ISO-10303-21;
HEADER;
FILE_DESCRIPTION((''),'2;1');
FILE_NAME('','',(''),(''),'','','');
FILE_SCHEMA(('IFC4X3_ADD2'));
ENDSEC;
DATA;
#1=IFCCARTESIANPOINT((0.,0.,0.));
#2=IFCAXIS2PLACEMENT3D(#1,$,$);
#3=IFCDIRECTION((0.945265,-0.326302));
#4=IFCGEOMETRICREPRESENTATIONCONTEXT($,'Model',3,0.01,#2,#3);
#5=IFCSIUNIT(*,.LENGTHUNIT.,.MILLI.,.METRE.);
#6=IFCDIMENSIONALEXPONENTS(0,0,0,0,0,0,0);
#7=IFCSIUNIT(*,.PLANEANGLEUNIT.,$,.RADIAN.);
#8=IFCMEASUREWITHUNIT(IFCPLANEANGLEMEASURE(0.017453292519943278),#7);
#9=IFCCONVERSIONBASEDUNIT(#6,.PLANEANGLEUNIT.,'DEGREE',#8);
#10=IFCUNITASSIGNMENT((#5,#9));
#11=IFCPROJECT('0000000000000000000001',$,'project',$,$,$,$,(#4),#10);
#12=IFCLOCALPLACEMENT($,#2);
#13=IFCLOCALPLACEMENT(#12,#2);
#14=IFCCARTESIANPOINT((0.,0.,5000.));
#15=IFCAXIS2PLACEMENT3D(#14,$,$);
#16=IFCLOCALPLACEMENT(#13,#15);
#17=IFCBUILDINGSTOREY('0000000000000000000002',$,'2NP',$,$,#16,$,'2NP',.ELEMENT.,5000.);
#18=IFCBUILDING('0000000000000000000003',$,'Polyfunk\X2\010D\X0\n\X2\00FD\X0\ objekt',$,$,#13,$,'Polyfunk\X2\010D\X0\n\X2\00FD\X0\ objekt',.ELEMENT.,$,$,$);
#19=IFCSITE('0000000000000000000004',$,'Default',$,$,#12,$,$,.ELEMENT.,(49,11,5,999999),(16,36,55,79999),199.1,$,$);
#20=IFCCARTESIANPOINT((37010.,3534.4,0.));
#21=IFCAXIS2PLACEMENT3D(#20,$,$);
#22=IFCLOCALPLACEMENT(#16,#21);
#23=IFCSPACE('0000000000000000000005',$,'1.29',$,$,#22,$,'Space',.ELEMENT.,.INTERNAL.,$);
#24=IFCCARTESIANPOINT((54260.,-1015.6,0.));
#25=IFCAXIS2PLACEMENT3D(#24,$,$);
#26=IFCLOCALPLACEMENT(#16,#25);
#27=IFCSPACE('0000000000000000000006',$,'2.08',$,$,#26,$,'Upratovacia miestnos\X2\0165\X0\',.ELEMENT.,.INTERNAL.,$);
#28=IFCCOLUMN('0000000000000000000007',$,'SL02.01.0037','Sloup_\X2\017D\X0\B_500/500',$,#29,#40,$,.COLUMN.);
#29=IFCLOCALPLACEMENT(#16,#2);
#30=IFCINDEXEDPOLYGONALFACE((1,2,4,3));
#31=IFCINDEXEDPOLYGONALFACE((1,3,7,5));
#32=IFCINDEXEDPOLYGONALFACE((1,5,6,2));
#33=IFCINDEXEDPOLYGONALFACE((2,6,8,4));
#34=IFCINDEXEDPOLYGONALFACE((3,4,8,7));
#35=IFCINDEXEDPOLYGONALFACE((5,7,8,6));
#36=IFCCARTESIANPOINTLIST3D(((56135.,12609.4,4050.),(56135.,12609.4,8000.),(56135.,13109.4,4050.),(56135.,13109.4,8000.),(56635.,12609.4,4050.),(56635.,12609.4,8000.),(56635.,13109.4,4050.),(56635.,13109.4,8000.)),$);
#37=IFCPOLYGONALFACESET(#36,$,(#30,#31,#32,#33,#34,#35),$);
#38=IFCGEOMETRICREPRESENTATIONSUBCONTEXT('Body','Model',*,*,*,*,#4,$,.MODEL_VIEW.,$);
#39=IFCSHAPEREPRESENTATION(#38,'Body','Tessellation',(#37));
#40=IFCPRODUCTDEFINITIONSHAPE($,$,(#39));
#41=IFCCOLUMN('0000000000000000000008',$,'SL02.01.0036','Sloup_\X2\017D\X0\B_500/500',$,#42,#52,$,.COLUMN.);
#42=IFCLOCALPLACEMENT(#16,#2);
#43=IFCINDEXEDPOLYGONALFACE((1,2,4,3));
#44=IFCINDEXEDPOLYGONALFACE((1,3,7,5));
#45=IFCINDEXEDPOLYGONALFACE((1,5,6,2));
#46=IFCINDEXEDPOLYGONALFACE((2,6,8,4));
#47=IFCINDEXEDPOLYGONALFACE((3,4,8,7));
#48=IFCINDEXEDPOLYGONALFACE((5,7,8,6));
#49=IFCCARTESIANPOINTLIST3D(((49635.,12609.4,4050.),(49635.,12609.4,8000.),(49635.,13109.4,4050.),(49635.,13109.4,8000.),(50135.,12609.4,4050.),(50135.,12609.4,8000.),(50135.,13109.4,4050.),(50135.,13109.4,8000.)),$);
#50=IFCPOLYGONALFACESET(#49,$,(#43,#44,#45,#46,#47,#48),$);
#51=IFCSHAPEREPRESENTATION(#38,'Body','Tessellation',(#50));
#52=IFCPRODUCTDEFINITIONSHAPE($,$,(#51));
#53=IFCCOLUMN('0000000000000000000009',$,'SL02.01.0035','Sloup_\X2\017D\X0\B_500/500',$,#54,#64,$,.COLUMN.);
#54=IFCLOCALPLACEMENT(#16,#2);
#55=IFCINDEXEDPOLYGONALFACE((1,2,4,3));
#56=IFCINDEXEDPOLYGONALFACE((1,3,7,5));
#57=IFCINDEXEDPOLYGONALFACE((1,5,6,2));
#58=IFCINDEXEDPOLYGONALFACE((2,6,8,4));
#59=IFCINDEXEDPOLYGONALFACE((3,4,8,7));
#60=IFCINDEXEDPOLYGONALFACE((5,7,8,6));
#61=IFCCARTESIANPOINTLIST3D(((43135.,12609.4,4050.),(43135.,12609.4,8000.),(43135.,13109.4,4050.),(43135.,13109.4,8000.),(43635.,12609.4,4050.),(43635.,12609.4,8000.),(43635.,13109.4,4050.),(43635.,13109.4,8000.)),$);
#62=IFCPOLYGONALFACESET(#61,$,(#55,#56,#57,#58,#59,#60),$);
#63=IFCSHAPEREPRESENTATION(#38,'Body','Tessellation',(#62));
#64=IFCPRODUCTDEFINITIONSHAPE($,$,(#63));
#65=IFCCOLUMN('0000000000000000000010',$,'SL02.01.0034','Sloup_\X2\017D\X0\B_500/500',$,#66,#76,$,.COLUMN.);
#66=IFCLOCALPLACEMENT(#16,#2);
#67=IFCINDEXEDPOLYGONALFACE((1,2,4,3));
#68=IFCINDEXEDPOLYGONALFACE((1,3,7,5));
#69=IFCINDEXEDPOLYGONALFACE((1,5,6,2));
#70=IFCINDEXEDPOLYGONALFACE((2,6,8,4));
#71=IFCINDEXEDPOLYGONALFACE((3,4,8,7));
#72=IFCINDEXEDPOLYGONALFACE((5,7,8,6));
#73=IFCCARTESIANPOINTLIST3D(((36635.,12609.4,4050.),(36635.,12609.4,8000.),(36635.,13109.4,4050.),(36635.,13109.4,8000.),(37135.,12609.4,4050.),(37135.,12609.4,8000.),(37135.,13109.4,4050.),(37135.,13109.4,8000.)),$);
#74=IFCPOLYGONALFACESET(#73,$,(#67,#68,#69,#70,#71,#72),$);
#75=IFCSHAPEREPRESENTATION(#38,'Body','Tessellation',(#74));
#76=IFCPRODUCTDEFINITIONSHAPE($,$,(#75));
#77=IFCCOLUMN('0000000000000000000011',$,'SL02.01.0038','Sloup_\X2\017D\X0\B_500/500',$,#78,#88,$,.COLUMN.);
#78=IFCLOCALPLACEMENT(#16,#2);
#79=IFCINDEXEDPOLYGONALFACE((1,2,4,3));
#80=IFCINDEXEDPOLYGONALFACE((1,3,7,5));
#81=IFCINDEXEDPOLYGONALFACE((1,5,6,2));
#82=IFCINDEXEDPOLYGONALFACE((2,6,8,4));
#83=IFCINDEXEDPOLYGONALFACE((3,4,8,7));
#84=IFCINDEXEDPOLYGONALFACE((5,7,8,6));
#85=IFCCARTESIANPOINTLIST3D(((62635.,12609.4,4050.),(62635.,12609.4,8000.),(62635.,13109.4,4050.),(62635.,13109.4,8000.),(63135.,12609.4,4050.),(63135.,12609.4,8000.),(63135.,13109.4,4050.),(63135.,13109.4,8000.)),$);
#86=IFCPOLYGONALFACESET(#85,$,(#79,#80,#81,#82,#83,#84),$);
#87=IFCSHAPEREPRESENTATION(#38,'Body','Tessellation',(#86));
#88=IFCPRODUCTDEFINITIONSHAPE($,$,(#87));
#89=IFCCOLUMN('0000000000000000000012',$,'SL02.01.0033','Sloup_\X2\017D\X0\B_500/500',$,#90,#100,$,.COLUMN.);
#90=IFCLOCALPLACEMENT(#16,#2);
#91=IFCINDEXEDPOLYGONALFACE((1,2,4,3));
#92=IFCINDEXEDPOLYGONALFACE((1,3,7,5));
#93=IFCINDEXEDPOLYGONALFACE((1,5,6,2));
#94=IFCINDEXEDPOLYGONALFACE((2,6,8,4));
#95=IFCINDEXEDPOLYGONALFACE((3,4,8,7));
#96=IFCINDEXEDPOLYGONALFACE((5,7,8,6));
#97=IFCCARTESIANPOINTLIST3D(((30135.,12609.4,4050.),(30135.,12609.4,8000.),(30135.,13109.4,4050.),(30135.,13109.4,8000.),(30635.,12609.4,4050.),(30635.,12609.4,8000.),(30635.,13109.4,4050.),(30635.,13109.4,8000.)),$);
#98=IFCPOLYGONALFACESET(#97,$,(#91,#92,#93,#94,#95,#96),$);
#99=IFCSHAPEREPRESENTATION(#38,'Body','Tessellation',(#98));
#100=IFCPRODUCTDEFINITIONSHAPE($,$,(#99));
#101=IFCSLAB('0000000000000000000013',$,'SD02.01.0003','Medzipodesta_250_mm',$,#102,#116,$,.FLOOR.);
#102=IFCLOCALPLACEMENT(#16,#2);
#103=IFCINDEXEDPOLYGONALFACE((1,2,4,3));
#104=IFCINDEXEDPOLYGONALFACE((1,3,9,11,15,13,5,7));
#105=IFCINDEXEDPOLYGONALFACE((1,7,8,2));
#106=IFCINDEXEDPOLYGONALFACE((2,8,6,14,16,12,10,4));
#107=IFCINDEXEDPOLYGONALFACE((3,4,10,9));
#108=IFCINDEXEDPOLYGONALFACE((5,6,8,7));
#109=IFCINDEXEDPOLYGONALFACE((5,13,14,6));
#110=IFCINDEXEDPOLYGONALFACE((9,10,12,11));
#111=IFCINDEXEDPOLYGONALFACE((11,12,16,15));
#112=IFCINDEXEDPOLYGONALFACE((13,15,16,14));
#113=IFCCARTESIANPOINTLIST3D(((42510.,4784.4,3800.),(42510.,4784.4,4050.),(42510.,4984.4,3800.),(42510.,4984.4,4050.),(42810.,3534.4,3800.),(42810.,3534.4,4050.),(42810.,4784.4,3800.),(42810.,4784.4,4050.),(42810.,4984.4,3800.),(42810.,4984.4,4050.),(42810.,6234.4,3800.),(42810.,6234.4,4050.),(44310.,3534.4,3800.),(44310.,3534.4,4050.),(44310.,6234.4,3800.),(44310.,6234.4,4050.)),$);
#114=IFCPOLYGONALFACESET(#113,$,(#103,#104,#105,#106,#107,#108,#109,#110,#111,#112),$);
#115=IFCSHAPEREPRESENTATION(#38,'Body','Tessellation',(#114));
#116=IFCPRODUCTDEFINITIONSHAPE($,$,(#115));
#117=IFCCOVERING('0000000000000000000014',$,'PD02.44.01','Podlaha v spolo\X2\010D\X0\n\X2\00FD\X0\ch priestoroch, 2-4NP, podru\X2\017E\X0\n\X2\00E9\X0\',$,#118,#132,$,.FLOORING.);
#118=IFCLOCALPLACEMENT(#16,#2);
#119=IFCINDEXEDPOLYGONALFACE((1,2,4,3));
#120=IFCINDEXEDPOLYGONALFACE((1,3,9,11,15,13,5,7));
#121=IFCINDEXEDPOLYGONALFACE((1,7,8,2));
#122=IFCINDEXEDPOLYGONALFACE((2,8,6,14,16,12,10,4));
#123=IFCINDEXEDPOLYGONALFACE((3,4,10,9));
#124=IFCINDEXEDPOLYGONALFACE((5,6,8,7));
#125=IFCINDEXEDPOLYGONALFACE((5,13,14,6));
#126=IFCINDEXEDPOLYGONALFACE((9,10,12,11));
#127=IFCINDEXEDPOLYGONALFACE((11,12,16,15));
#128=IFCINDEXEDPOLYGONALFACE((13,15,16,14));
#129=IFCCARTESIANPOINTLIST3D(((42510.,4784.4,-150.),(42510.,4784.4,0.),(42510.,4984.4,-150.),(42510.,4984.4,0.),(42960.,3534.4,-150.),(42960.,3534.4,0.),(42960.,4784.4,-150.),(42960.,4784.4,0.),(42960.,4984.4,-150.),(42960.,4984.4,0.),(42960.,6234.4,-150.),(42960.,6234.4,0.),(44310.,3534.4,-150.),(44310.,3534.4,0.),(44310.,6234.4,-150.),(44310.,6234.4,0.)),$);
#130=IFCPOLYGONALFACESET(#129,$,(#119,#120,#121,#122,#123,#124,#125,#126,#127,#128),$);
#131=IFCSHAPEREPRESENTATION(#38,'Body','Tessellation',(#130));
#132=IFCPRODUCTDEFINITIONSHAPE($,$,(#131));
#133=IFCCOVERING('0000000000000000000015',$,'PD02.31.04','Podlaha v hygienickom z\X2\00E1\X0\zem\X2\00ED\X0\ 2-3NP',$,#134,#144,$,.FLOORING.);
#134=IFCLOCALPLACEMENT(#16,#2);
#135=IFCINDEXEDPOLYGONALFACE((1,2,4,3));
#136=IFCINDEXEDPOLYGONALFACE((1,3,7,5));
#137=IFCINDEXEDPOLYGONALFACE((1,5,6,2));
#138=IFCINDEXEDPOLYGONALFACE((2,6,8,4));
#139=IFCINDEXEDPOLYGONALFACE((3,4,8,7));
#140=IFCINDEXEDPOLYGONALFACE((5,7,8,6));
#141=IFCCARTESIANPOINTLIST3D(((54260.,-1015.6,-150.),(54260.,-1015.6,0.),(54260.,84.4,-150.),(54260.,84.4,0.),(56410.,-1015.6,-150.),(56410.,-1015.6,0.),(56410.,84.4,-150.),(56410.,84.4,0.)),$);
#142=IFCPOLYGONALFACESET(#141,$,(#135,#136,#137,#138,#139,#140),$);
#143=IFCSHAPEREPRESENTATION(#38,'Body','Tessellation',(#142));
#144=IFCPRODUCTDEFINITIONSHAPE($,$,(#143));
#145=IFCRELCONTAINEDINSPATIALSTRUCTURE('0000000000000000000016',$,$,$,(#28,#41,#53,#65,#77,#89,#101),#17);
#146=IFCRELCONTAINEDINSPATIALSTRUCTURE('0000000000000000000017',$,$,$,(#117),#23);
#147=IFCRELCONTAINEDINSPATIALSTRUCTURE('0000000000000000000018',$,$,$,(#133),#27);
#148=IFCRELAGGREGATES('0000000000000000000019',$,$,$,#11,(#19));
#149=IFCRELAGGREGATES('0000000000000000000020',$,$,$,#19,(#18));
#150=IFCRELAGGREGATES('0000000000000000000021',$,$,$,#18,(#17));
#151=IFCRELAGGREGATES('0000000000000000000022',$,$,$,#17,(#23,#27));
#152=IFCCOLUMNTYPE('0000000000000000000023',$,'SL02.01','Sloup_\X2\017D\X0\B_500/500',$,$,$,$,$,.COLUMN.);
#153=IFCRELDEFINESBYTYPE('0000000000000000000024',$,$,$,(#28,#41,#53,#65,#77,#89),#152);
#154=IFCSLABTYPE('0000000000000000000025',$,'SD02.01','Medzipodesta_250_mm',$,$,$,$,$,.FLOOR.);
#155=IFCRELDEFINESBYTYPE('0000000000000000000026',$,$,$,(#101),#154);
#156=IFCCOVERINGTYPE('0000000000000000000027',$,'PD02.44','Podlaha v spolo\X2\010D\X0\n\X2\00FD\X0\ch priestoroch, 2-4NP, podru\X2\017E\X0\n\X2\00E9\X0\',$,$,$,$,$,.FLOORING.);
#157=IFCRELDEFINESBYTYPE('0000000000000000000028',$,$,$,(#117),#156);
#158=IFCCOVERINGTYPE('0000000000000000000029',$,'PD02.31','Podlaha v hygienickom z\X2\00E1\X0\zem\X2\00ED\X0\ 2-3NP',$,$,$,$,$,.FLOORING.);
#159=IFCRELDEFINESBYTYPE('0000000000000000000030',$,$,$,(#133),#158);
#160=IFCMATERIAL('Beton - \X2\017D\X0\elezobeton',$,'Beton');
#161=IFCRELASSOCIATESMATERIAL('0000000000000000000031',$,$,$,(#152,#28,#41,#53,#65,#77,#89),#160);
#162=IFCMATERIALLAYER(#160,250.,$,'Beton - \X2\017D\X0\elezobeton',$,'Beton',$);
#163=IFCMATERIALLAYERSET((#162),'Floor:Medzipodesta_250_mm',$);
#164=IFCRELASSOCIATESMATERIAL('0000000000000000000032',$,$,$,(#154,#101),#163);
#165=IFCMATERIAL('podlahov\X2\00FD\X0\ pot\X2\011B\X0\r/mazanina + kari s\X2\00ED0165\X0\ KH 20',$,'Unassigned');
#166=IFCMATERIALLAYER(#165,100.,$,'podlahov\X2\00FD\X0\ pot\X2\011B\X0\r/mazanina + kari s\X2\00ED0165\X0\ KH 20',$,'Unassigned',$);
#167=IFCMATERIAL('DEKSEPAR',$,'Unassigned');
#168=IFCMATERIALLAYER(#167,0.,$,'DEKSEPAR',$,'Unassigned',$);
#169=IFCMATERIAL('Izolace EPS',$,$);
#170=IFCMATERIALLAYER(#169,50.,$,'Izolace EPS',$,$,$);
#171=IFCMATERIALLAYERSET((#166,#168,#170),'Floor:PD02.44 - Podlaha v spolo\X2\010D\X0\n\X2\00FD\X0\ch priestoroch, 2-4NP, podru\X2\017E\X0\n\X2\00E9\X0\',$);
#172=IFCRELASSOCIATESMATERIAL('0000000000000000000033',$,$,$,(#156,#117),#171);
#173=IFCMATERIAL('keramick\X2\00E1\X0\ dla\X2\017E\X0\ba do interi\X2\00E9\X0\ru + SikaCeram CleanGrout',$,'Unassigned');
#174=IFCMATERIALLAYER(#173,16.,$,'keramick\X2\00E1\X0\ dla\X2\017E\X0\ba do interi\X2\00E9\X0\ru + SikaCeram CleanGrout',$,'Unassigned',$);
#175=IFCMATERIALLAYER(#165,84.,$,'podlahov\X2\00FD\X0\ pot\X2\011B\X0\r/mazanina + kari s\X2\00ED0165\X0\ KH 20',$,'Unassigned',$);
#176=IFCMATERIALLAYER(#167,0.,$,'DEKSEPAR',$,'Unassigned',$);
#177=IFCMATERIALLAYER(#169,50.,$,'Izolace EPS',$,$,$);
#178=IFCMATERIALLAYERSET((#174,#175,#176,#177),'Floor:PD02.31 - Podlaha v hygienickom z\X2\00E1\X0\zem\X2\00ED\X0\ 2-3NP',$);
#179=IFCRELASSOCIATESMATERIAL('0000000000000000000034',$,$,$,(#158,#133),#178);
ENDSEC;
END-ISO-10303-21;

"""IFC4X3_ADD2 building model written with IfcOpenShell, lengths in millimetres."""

from ifc_helpers import new_model, entity, si_unit, converted_unit, direction, frame, frame_2d, origin, origin_2d_with_axis, place, context, subcontext, project, spatial, polyline, rectangle, outline, extrude, source, transform, mapped, material, layer, layer_set, layer_usage, material_profile, profile_set, profile_usage, type_object, type_shapes, element, save


model = new_model("IFC4X3_ADD2")

# Units and contexts
model_context = context("Model", 3, precision=0.01, world=origin(), true_north=direction((0.945265, -0.326302)))
body_context = subcontext(model_context, "Body", "Model", "MODEL_VIEW")
ifc_project = project(units=[si_unit("LENGTHUNIT", "METRE", prefix="MILLI"), converted_unit("PLANEANGLEUNIT", "DEGREE", entity("IfcPlaneAngleMeasure", 0.017453292519943278), si_unit("PLANEANGLEUNIT", "RADIAN"), dimensions=[0, 0, 0, 0, 0, 0, 0])], contexts=[model_context])

# Site, building, storey
site_placement = place(None, origin())
site = spatial("IfcSite", under=ifc_project, at=site_placement, Name="Default", CompositionType="ELEMENT", RefLatitude=(49, 11, 5, 999999), RefLongitude=(16, 36, 55, 79999), RefElevation=199.1)
building_placement = place(site_placement, origin())
building = spatial("IfcBuilding", under=site, at=building_placement, Name="Polyfunkčný objekt", LongName="Polyfunkčný objekt", CompositionType="ELEMENT")
storey_placement = place(building_placement, frame((0.0, 0.0, 5000.0)))
storey = spatial("IfcBuildingStorey", under=building, at=storey_placement, Name="2NP", LongName="2NP", CompositionType="ELEMENT", Elevation=5000.0)

# Columns
ifc_material_1 = material(Name="Beton - Železobeton", Category="Beton")
ifc_material_profile_1 = material_profile(ifc_material_1, rectangle(XDim=500.0, YDim=500.0, at=frame_2d((0.0, 0.0), x_axis=(1.0, 0.0))), Name="Sloup_ŽB_500/500")
ifc_profile_set_1 = profile_set([ifc_material_profile_1], Name="Sloup_ŽB_500/500")
ifc_profile_usage_1 = profile_usage(ifc_profile_set_1)
column_type = type_object("IfcColumnType", Name="SL02.01", Description="Sloup_ŽB_500/500", PredefinedType="COLUMN", material=ifc_profile_set_1)
shared_shape_1 = source(origin(), body_context, "Body", "SweptSolid", [
    extrude(rectangle(XDim=500.0, YDim=500.0, at=frame_2d((0.0, 0.0), x_axis=(1.0, 0.0))), frame((56385.0, 12859.4, 9050.0)), (0.0, 0.0, 1.0), 3950.0),
])
column_1_placement = place(storey_placement, frame((0.0, 0.0, -5000.0)))
element("IfcColumn", 1, at=column_1_placement, inside=storey, type_object=column_type, material=ifc_profile_usage_1, Name="SL02.01.0037", Description="Sloup_ŽB_500/500", PredefinedType="COLUMN", context=body_context, shape_type="MappedRepresentation", body=[
    mapped(shared_shape_1, transform((0.0, 0.0, 0.0), scale=1.0)),
])
shared_shape_2 = source(origin(), body_context, "Body", "SweptSolid", [
    extrude(rectangle(XDim=500.0, YDim=500.0, at=origin_2d_with_axis()), frame((49885.0, 12859.4, 9050.0)), (0.0, 0.0, 1.0), 3950.0),
])
column_2_placement = place(storey_placement, frame((0.0, 0.0, -5000.0)))
element("IfcColumn", 2, at=column_2_placement, inside=storey, type_object=column_type, material=ifc_profile_usage_1, Name="SL02.01.0036", Description="Sloup_ŽB_500/500", PredefinedType="COLUMN", context=body_context, shape_type="MappedRepresentation", body=[
    mapped(shared_shape_2, transform((0.0, 0.0, 0.0), scale=1.0)),
])
shared_shape_3 = source(origin(), body_context, "Body", "SweptSolid", [
    extrude(rectangle(XDim=500.0, YDim=500.0, at=origin_2d_with_axis()), frame((43385.0, 12859.4, 9050.0)), (0.0, 0.0, 1.0), 3950.0),
])
column_3_placement = place(storey_placement, frame((0.0, 0.0, -5000.0)))
element("IfcColumn", 3, at=column_3_placement, inside=storey, type_object=column_type, material=ifc_profile_usage_1, Name="SL02.01.0035", Description="Sloup_ŽB_500/500", PredefinedType="COLUMN", context=body_context, shape_type="MappedRepresentation", body=[
    mapped(shared_shape_3, transform((0.0, 0.0, 0.0), scale=1.0)),
])
shared_shape_4 = source(origin(), body_context, "Body", "SweptSolid", [
    extrude(rectangle(XDim=500.0, YDim=500.0, at=origin_2d_with_axis()), frame((36885.0, 12859.4, 9050.0)), (0.0, 0.0, 1.0), 3950.0),
])
column_4_placement = place(storey_placement, frame((0.0, 0.0, -5000.0)))
element("IfcColumn", 4, at=column_4_placement, inside=storey, type_object=column_type, material=ifc_profile_usage_1, Name="SL02.01.0034", Description="Sloup_ŽB_500/500", PredefinedType="COLUMN", context=body_context, shape_type="MappedRepresentation", body=[
    mapped(shared_shape_4, transform((0.0, 0.0, 0.0), scale=1.0)),
])
shared_shape_5 = source(origin(), body_context, "Body", "SweptSolid", [
    extrude(rectangle(XDim=500.0, YDim=500.0, at=origin_2d_with_axis()), frame((62885.0, 12859.4, 9050.0), z_axis=(0.0, 0.0, 1.0), x_axis=(-1.0, 0.0, 0.0)), (0.0, 0.0, 1.0), 3950.0),
])
column_5_placement = place(storey_placement, frame((0.0, 0.0, -5000.0)))
element("IfcColumn", 5, at=column_5_placement, inside=storey, type_object=column_type, material=ifc_profile_usage_1, Name="SL02.01.0038", Description="Sloup_ŽB_500/500", PredefinedType="COLUMN", context=body_context, shape_type="MappedRepresentation", body=[
    mapped(shared_shape_5, transform((0.0, 0.0, 0.0), scale=1.0)),
])
shared_shape_6 = source(origin(), body_context, "Body", "SweptSolid", [
    extrude(rectangle(XDim=500.0, YDim=500.0, at=origin_2d_with_axis()), frame((30385.0, 12859.4, 9050.0), z_axis=(0.0, 0.0, 1.0), x_axis=(-1.0, 0.0, 0.0)), (0.0, 0.0, 1.0), 3950.0),
])
type_shapes(column_type, [shared_shape_1, shared_shape_2, shared_shape_3, shared_shape_4, shared_shape_5, shared_shape_6])
column_6_placement = place(storey_placement, frame((0.0, 0.0, -5000.0)))
element("IfcColumn", 6, at=column_6_placement, inside=storey, type_object=column_type, material=ifc_profile_usage_1, Name="SL02.01.0033", Description="Sloup_ŽB_500/500", PredefinedType="COLUMN", context=body_context, shape_type="MappedRepresentation", body=[
    mapped(shared_shape_6, transform((0.0, 0.0, 0.0), scale=1.0)),
])

# Slab
ifc_layer_1 = layer(ifc_material_1, 250.0, Name="Beton - Železobeton", Category="Beton")
ifc_layer_set_1 = layer_set([ifc_layer_1], Name="Floor:Medzipodesta_250_mm")
ifc_layer_usage_1 = layer_usage(ifc_layer_set_1, "AXIS3", "POSITIVE", 0.0)
slab_type_1 = type_object("IfcSlabType", Name="SD02.01", Description="Medzipodesta_250_mm", PredefinedType="FLOOR", material=ifc_layer_set_1)
slab_1_placement = place(storey_placement, origin())
element("IfcSlab", 7, at=slab_1_placement, inside=storey, type_object=slab_type_1, material=ifc_layer_usage_1, Name="SD02.01.0003", Description="Medzipodesta_250_mm", PredefinedType="FLOOR", context=body_context, shape_type="SweptSolid", body=[
    extrude(outline(polyline([(-100.0, -600.0), (100.0, -600.0), (100.0, -300.0), (1350.0, -300.0), (1350.0, 1200.0), (-1350.0, 1200.0), (-1350.0, -300.0), (-100.0, -300.0), (-100.0, -600.0)])), frame((43110.0, 4884.4, 4050.0), z_axis=(0.0, 0.0, -1.0), x_axis=(0.0, 1.0, 0.0)), (0.0, 0.0, 1.0), 250.0),
])

# Shared definitions
space_1_placement = place(storey_placement, frame((37010.0, 3534.4, 0.0)))
space_1 = spatial("IfcSpace", under=storey, at=space_1_placement, Name="1.29", LongName="Space", CompositionType="ELEMENT", PredefinedType="INTERNAL")

# Covering
ifc_material_2 = material(Name="podlahový potěr/mazanina + kari síť KH 20", Category="Unassigned")
ifc_layer_2 = layer(ifc_material_2, 100.0, Name="podlahový potěr/mazanina + kari síť KH 20", Category="Unassigned")
ifc_material_3 = material(Name="DEKSEPAR", Category="Unassigned")
ifc_layer_3 = layer(ifc_material_3, 0.0, Name="DEKSEPAR", Category="Unassigned")
ifc_material_4 = material(Name="Izolace EPS")
ifc_layer_4 = layer(ifc_material_4, 50.0, Name="Izolace EPS")
ifc_layer_set_2 = layer_set([ifc_layer_2, ifc_layer_3, ifc_layer_4], Name="Floor:PD02.44 - Podlaha v spoločných priestoroch, 2-4NP, podružné")
ifc_layer_usage_2 = layer_usage(ifc_layer_set_2, "AXIS3", "POSITIVE", 0.0)
covering_type_1 = type_object("IfcCoveringType", Name="PD02.44", Description="Podlaha v spoločných priestoroch, 2-4NP, podružné", PredefinedType="FLOORING", material=ifc_layer_set_2)
covering_1_placement = place(storey_placement, origin())
element("IfcCovering", 8, at=covering_1_placement, inside=space_1, type_object=covering_type_1, material=ifc_layer_usage_2, Name="PD02.44.01", Description="Podlaha v spoločných priestoroch, 2-4NP, podružné", PredefinedType="FLOORING", context=body_context, shape_type="SweptSolid", body=[
    extrude(outline(polyline([(-100.0, -675.0), (100.0, -675.0), (100.0, -225.0), (1350.0, -225.0), (1350.0, 1125.0), (-1350.0, 1125.0), (-1350.0, -225.0), (-100.0, -225.0), (-100.0, -675.0)])), frame((43185.0, 4884.4, 0.0), z_axis=(0.0, 0.0, -1.0), x_axis=(0.0, 1.0, 0.0)), (0.0, 0.0, 1.0), 150.0),
])

# Shared definitions
ifc_material_5 = material(Name="keramická dlažba do interiéru + SikaCeram CleanGrout", Category="Unassigned")
ifc_layer_5 = layer(ifc_material_5, 16.0, Name="keramická dlažba do interiéru + SikaCeram CleanGrout", Category="Unassigned")
ifc_layer_6 = layer(ifc_material_2, 84.0, Name="podlahový potěr/mazanina + kari síť KH 20", Category="Unassigned")
ifc_layer_7 = layer(ifc_material_3, 0.0, Name="DEKSEPAR", Category="Unassigned")
ifc_layer_8 = layer(ifc_material_4, 50.0, Name="Izolace EPS")
ifc_layer_set_3 = layer_set([ifc_layer_5, ifc_layer_6, ifc_layer_7, ifc_layer_8], Name="Floor:PD02.31 - Podlaha v hygienickom zázemí 2-3NP")
covering_type_2 = type_object("IfcCoveringType", Name="PD02.31", Description="Podlaha v hygienickom zázemí 2-3NP", PredefinedType="FLOORING", material=ifc_layer_set_3)

# Shared definitions
space_2_placement = place(storey_placement, frame((54260.0, -1015.6, 0.0)))
space_2 = spatial("IfcSpace", under=storey, at=space_2_placement, Name="2.08", LongName="Upratovacia miestnosť", CompositionType="ELEMENT", PredefinedType="INTERNAL")

# Covering
ifc_layer_usage_3 = layer_usage(ifc_layer_set_3, "AXIS3", "POSITIVE", 0.0)
covering_2_placement = place(storey_placement, origin())
element("IfcCovering", 9, at=covering_2_placement, inside=space_2, type_object=covering_type_2, material=ifc_layer_usage_3, Name="PD02.31.04", Description="Podlaha v hygienickom zázemí 2-3NP", PredefinedType="FLOORING", context=body_context, shape_type="SweptSolid", body=[
    extrude(rectangle(XDim=1100.0, YDim=2150.0, at=frame_2d((0.0, 0.0), x_axis=(1.0, 0.0))), frame((55335.0, -465.6, 0.0), z_axis=(0.0, 0.0, -1.0), x_axis=(0.0, 1.0, 0.0)), (0.0, 0.0, 1.0), 150.0),
])

save(model, "model.ifc")
